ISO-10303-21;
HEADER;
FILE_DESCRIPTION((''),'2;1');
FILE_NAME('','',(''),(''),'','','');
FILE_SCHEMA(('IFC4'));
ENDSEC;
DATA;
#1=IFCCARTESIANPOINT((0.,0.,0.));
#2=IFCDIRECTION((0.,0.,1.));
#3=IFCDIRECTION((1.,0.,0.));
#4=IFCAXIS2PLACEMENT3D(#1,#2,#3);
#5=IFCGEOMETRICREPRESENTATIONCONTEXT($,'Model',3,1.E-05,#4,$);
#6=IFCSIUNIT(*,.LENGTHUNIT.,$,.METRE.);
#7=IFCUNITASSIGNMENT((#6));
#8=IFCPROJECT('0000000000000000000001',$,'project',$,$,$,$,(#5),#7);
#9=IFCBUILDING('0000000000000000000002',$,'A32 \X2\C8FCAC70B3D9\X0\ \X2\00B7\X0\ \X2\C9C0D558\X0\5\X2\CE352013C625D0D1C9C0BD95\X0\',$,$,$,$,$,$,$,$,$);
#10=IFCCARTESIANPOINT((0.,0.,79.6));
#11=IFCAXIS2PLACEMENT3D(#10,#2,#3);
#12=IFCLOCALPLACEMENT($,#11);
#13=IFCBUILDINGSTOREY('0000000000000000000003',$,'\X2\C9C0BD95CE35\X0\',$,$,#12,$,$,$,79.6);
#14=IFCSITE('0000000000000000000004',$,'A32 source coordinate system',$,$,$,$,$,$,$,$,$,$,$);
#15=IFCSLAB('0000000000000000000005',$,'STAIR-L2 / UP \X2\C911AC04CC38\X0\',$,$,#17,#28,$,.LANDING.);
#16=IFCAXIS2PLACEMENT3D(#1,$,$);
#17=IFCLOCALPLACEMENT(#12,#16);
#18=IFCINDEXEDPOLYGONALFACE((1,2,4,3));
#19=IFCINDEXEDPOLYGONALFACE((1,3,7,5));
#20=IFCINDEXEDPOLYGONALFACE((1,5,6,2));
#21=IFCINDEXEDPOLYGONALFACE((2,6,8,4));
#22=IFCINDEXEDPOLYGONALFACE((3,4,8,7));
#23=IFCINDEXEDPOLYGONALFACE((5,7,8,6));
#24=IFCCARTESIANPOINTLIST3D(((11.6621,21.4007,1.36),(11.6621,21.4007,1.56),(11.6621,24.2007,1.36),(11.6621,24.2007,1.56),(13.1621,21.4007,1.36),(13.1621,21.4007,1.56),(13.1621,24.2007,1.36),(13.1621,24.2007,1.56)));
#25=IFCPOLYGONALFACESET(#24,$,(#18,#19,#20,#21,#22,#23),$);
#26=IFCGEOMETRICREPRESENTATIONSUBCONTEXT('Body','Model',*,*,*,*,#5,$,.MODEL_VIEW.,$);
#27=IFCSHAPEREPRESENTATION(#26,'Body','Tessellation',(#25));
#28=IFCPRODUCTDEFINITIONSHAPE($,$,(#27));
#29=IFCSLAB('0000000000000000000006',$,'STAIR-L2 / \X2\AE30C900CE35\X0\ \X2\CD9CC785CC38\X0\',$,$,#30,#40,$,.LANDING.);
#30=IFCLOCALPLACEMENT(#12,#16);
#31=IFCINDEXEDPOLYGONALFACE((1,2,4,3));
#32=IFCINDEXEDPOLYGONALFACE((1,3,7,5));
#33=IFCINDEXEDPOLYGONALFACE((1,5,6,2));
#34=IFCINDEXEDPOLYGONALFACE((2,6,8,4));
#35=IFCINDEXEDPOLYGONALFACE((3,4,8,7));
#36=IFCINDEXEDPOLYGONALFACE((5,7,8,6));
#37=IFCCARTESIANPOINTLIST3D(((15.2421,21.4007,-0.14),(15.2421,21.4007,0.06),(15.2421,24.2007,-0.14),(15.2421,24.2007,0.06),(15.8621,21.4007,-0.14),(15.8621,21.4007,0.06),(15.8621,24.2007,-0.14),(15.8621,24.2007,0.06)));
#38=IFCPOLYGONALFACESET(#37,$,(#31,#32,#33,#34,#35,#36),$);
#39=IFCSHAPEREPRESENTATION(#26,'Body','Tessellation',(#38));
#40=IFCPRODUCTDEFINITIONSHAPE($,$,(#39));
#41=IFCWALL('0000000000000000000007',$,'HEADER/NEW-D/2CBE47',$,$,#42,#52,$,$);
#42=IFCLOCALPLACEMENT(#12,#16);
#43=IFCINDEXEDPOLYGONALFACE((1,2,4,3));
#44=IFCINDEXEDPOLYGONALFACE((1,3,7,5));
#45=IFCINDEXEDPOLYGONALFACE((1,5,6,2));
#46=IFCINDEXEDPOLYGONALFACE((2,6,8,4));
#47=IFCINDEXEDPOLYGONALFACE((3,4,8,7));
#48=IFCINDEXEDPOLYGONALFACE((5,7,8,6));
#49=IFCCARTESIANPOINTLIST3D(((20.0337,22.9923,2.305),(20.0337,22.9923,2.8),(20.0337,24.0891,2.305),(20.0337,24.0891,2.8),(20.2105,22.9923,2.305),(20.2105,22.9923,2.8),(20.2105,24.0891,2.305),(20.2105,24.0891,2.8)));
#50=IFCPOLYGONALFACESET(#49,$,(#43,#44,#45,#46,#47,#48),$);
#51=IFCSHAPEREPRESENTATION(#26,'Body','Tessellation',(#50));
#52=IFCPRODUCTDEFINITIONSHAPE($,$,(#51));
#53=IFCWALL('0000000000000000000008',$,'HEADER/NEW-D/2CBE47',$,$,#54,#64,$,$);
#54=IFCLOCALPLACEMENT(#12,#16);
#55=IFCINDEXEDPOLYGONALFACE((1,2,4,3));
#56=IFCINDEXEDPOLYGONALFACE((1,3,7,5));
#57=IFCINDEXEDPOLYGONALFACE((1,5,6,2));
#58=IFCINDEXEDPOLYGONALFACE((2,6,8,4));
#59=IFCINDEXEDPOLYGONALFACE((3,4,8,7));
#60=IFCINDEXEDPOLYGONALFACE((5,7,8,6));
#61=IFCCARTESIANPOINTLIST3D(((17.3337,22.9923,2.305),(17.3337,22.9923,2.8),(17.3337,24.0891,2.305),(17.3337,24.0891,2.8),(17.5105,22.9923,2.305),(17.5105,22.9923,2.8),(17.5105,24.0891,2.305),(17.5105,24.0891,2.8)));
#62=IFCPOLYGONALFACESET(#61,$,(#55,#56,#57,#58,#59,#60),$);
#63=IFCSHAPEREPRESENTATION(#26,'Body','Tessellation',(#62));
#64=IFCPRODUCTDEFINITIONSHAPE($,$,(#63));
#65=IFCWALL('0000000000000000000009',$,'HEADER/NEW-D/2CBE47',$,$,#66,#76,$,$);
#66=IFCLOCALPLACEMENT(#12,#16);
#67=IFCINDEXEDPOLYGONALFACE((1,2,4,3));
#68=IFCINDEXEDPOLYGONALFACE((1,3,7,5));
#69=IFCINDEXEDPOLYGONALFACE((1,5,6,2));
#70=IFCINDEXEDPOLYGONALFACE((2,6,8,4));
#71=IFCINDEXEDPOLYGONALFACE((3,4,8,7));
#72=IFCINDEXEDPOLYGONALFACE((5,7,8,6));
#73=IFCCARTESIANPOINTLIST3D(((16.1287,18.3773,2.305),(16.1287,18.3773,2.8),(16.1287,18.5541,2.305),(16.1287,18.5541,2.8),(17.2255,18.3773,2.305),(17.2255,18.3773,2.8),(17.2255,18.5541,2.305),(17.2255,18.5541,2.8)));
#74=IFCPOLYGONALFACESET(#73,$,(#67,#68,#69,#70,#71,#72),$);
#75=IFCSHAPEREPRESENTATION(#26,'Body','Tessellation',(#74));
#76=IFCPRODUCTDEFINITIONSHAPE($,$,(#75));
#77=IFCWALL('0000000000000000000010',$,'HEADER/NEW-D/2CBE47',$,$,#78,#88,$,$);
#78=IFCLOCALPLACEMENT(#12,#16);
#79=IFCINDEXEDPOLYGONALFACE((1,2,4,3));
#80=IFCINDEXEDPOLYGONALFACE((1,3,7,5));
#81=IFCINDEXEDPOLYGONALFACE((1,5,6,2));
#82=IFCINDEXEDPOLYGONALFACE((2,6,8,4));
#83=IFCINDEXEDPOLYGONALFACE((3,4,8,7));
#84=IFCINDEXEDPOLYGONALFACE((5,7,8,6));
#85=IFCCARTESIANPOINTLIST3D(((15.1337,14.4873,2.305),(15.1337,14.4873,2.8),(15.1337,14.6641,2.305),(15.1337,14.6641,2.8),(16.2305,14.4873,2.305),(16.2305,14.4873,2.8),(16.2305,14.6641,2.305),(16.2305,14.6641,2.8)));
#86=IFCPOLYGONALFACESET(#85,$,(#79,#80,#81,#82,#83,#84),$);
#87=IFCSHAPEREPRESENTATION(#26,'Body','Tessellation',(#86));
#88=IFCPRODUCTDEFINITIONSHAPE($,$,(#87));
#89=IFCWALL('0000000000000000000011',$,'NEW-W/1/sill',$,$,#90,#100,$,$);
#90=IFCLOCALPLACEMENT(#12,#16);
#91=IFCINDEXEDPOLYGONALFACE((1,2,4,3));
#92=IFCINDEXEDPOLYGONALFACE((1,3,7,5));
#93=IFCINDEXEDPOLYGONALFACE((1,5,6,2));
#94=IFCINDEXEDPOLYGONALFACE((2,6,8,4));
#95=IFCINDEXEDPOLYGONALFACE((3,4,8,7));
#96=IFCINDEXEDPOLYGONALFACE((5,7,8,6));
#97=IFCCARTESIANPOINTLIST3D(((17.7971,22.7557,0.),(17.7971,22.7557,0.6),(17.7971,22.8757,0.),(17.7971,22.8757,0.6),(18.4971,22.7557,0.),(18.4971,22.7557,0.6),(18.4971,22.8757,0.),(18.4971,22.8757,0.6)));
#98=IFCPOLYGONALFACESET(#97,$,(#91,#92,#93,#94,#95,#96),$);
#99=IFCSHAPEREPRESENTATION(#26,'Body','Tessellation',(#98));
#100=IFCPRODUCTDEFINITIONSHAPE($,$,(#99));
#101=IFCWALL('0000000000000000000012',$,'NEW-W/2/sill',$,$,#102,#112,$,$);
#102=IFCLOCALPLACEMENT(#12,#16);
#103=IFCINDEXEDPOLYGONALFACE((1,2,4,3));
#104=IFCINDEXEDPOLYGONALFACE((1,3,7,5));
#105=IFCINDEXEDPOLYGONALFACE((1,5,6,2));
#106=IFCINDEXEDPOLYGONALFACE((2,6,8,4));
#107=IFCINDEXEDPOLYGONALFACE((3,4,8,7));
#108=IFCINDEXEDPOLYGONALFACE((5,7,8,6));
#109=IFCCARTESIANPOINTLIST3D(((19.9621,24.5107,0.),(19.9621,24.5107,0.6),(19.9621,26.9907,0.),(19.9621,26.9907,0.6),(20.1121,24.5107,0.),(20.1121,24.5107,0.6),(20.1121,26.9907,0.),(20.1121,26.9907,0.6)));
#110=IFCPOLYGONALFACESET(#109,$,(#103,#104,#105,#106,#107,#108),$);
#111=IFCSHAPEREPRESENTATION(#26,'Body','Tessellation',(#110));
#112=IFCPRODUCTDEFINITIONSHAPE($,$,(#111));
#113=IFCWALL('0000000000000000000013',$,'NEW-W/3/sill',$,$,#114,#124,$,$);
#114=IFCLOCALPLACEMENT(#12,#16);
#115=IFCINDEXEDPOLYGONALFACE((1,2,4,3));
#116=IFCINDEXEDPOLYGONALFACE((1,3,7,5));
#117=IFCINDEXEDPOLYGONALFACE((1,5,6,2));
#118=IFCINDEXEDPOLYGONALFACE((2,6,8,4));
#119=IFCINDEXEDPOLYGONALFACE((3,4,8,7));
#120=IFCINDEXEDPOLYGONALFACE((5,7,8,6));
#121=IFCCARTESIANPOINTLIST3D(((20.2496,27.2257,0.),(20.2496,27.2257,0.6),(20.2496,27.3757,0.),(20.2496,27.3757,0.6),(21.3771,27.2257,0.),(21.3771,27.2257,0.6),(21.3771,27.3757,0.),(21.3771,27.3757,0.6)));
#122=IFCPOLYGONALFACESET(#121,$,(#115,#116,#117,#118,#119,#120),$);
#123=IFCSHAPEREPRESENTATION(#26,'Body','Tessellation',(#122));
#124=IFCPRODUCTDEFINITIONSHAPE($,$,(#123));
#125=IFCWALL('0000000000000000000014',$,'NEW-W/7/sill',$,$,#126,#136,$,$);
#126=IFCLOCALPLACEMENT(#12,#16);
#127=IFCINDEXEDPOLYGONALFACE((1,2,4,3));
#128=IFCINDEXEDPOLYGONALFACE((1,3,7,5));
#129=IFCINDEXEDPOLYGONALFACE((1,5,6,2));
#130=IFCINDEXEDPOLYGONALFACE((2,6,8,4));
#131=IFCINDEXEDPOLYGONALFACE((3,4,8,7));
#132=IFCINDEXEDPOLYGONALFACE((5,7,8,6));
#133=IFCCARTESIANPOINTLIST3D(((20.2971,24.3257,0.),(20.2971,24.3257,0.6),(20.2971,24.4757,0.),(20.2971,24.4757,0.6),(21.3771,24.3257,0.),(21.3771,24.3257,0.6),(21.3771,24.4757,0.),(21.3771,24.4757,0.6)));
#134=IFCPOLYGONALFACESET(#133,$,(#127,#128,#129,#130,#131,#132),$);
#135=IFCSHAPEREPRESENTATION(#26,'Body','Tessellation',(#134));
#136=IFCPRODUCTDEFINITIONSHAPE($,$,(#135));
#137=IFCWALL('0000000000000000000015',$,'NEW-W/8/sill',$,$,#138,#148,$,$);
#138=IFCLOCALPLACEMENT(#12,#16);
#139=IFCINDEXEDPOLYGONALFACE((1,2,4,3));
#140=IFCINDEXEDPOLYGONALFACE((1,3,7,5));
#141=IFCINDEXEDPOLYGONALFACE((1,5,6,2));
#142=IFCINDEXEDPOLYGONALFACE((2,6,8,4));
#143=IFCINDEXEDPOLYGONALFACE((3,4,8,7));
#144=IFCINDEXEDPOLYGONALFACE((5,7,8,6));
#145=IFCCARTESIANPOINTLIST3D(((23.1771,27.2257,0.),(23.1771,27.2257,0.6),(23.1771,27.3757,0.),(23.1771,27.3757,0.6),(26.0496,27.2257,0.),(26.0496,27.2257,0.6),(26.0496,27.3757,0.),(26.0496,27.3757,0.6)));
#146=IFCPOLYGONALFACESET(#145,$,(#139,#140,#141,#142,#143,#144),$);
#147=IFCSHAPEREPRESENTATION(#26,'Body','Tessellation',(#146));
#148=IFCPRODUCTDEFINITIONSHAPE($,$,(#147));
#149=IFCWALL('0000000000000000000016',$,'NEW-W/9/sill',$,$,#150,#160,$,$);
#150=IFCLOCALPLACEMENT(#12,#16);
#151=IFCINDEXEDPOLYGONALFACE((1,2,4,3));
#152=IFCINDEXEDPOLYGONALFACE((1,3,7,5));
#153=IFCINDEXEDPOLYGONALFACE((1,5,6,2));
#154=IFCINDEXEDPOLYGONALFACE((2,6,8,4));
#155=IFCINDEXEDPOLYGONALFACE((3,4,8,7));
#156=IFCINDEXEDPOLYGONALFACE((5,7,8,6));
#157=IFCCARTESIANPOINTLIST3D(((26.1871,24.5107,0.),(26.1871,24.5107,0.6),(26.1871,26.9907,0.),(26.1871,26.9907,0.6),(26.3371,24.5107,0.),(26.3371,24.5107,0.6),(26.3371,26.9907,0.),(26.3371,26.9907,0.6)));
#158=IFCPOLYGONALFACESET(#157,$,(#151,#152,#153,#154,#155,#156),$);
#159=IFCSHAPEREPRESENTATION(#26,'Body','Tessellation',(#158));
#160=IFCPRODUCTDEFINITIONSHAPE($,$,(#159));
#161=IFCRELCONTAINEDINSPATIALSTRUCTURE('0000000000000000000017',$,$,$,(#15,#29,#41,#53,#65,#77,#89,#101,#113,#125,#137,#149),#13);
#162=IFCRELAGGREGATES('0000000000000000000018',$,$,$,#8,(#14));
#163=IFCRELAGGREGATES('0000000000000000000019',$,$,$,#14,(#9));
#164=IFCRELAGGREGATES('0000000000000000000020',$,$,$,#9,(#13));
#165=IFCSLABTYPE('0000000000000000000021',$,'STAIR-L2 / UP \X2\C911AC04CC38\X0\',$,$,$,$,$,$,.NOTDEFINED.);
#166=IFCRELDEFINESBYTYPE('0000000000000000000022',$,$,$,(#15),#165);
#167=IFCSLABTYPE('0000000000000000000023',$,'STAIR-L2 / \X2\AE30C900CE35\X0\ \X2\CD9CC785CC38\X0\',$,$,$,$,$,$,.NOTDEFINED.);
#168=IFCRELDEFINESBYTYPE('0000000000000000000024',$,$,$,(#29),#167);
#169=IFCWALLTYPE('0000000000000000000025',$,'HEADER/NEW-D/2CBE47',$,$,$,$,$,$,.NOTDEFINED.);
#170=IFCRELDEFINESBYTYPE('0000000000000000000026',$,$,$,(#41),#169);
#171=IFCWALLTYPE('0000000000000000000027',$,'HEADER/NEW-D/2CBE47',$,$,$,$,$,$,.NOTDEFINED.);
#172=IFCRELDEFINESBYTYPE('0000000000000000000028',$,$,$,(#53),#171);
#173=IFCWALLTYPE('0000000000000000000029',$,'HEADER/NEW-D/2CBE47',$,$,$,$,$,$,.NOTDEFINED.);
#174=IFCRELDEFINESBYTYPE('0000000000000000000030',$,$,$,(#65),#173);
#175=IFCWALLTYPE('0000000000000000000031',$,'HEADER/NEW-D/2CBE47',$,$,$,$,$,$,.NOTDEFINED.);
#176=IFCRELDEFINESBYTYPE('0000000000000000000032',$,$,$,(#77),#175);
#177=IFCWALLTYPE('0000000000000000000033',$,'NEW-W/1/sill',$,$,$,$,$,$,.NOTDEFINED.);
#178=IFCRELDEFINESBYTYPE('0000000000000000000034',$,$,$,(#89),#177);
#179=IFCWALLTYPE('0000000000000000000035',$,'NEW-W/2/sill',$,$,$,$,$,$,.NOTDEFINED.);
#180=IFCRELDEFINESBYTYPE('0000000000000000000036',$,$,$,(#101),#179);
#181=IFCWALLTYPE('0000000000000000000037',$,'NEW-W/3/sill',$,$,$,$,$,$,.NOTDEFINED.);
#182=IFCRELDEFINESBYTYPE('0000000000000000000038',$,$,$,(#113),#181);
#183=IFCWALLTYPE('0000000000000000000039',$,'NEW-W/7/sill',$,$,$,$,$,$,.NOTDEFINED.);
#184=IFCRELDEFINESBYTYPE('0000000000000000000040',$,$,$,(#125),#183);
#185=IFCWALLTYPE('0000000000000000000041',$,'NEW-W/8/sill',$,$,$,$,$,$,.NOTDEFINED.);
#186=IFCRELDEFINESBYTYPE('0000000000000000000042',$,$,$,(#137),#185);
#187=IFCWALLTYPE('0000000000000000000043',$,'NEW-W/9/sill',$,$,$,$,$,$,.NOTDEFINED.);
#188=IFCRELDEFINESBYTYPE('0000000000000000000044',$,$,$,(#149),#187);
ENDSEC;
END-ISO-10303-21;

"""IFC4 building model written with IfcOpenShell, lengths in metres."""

from ifc_helpers import new_model, si_unit, frame, origin, origin_with_axes, place, context, subcontext, project, spatial, polyline, outline, extrude, source, transform, mapped, type_object, type_shapes, element, save


model = new_model("IFC4")

# Units and contexts
model_context = context("Model", 3, precision=1e-05, world=origin_with_axes())
body_context = subcontext(model_context, "Body", "Model", "MODEL_VIEW")
ifc_project = project(units=[si_unit("LENGTHUNIT", "METRE")], contexts=[model_context])

# Site, building, storey
site = spatial("IfcSite", under=ifc_project, Name="A32 source coordinate system")
building = spatial("IfcBuilding", under=site, Name="A32 주거동 · 지하5층–옥탑지붕")
storey_placement = place(None, frame((0.0, 0.0, 79.6), z_axis=(0.0, 0.0, 1.0), x_axis=(1.0, 0.0, 0.0)))
storey = spatial("IfcBuildingStorey", under=building, at=storey_placement, Name="지붕층", Elevation=79.6)

# Slabs
slab_type_1 = type_object("IfcSlabType", Name="STAIR-L2 / UP 중간참", PredefinedType="NOTDEFINED")
shared_shape_1 = source(origin(), body_context, "Body", "SweptSolid", [
    extrude(outline(polyline([(11.6621, 21.4007), (11.6621, 24.2007), (13.1621, 24.2007), (13.1621, 21.4007), (11.6621, 21.4007)])), frame((0.0, 0.0, 1.36)), (0.0, 0.0, 1.0), 0.2),
])
type_shapes(slab_type_1, [shared_shape_1])
slab_1_placement = place(storey_placement, origin_with_axes())
element("IfcSlab", 1, at=slab_1_placement, inside=storey, type_object=slab_type_1, Name="STAIR-L2 / UP 중간참", PredefinedType="LANDING", context=body_context, shape_type="MappedRepresentation", body=[
    mapped(shared_shape_1, transform((0.0, 0.0, 0.0), scale=1.0)),
])
slab_type_2 = type_object("IfcSlabType", Name="STAIR-L2 / 기준층 출입참", PredefinedType="NOTDEFINED")
shared_shape_2 = source(origin(), body_context, "Body", "SweptSolid", [
    extrude(outline(polyline([(15.2421, 21.4007), (15.2421, 24.2007), (15.8621, 24.2007), (15.8621, 21.4007), (15.2421, 21.4007)])), frame((0.0, 0.0, -0.14)), (0.0, 0.0, 1.0), 0.2),
])
type_shapes(slab_type_2, [shared_shape_2])
slab_2_placement = place(storey_placement, origin_with_axes())
element("IfcSlab", 2, at=slab_2_placement, inside=storey, type_object=slab_type_2, Name="STAIR-L2 / 기준층 출입참", PredefinedType="LANDING", context=body_context, shape_type="MappedRepresentation", body=[
    mapped(shared_shape_2, transform((0.0, 0.0, 0.0), scale=1.0)),
])

# Walls
wall_type_1 = type_object("IfcWallType", Name="HEADER/NEW-D/2CBE47", PredefinedType="NOTDEFINED")
shared_shape_3 = source(origin(), body_context, "Body", "SweptSolid", [
    extrude(outline(polyline([(20.0337, 22.9923), (20.0337, 24.0891), (20.2105, 24.0891), (20.2105, 22.9923), (20.0337, 22.9923)])), frame((0.0, 0.0, 2.305)), (0.0, 0.0, 1.0), 0.495),
])
type_shapes(wall_type_1, [shared_shape_3])
wall_1_placement = place(storey_placement, origin_with_axes())
element("IfcWall", 3, at=wall_1_placement, inside=storey, type_object=wall_type_1, Name="HEADER/NEW-D/2CBE47", context=body_context, shape_type="MappedRepresentation", body=[
    mapped(shared_shape_3, transform((0.0, 0.0, 0.0), scale=1.0)),
])
wall_type_2 = type_object("IfcWallType", Name="HEADER/NEW-D/2CBE47", PredefinedType="NOTDEFINED")
shared_shape_4 = source(origin(), body_context, "Body", "SweptSolid", [
    extrude(outline(polyline([(17.3337, 22.9923), (17.3337, 24.0891), (17.5105, 24.0891), (17.5105, 22.9923), (17.3337, 22.9923)])), frame((0.0, 0.0, 2.305)), (0.0, 0.0, 1.0), 0.495),
])
type_shapes(wall_type_2, [shared_shape_4])
wall_2_placement = place(storey_placement, origin_with_axes())
element("IfcWall", 4, at=wall_2_placement, inside=storey, type_object=wall_type_2, Name="HEADER/NEW-D/2CBE47", context=body_context, shape_type="MappedRepresentation", body=[
    mapped(shared_shape_4, transform((0.0, 0.0, 0.0), scale=1.0)),
])
wall_type_3 = type_object("IfcWallType", Name="HEADER/NEW-D/2CBE47", PredefinedType="NOTDEFINED")
shared_shape_5 = source(origin(), body_context, "Body", "SweptSolid", [
    extrude(outline(polyline([(16.1287, 18.3773), (16.1287, 18.5541), (17.2255, 18.5541), (17.2255, 18.3773), (16.1287, 18.3773)])), frame((0.0, 0.0, 2.305)), (0.0, 0.0, 1.0), 0.495),
])
type_shapes(wall_type_3, [shared_shape_5])
wall_3_placement = place(storey_placement, origin_with_axes())
element("IfcWall", 5, at=wall_3_placement, inside=storey, type_object=wall_type_3, Name="HEADER/NEW-D/2CBE47", context=body_context, shape_type="MappedRepresentation", body=[
    mapped(shared_shape_5, transform((0.0, 0.0, 0.0), scale=1.0)),
])
wall_type_4 = type_object("IfcWallType", Name="HEADER/NEW-D/2CBE47", PredefinedType="NOTDEFINED")
shared_shape_6 = source(origin(), body_context, "Body", "SweptSolid", [
    extrude(outline(polyline([(15.1337, 14.4873), (15.1337, 14.6641), (16.2305, 14.6641), (16.2305, 14.4873), (15.1337, 14.4873)])), frame((0.0, 0.0, 2.305)), (0.0, 0.0, 1.0), 0.495),
])
type_shapes(wall_type_4, [shared_shape_6])
wall_4_placement = place(storey_placement, origin_with_axes())
element("IfcWall", 6, at=wall_4_placement, inside=storey, type_object=wall_type_4, Name="HEADER/NEW-D/2CBE47", context=body_context, shape_type="MappedRepresentation", body=[
    mapped(shared_shape_6, transform((0.0, 0.0, 0.0), scale=1.0)),
])
wall_type_5 = type_object("IfcWallType", Name="NEW-W/1/sill", PredefinedType="NOTDEFINED")
shared_shape_7 = source(origin(), body_context, "Body", "SweptSolid", [
    extrude(outline(polyline([(17.7971, 22.7557), (17.7971, 22.8757), (18.4971, 22.8757), (18.4971, 22.7557), (17.7971, 22.7557)])), origin(), (0.0, 0.0, 1.0), 0.6),
])
type_shapes(wall_type_5, [shared_shape_7])
wall_5_placement = place(storey_placement, origin_with_axes())
element("IfcWall", 7, at=wall_5_placement, inside=storey, type_object=wall_type_5, Name="NEW-W/1/sill", context=body_context, shape_type="MappedRepresentation", body=[
    mapped(shared_shape_7, transform((0.0, 0.0, 0.0), scale=1.0)),
])
wall_type_6 = type_object("IfcWallType", Name="NEW-W/2/sill", PredefinedType="NOTDEFINED")
shared_shape_8 = source(origin(), body_context, "Body", "SweptSolid", [
    extrude(outline(polyline([(19.9621, 24.5107), (19.9621, 26.9907), (20.1121, 26.9907), (20.1121, 24.5107), (19.9621, 24.5107)])), origin(), (0.0, 0.0, 1.0), 0.6),
])
type_shapes(wall_type_6, [shared_shape_8])
wall_6_placement = place(storey_placement, origin_with_axes())
element("IfcWall", 8, at=wall_6_placement, inside=storey, type_object=wall_type_6, Name="NEW-W/2/sill", context=body_context, shape_type="MappedRepresentation", body=[
    mapped(shared_shape_8, transform((0.0, 0.0, 0.0), scale=1.0)),
])
wall_type_7 = type_object("IfcWallType", Name="NEW-W/3/sill", PredefinedType="NOTDEFINED")
shared_shape_9 = source(origin(), body_context, "Body", "SweptSolid", [
    extrude(outline(polyline([(20.2496, 27.2257), (20.2496, 27.3757), (21.3771, 27.3757), (21.3771, 27.2257), (20.2496, 27.2257)])), origin(), (0.0, 0.0, 1.0), 0.6),
])
type_shapes(wall_type_7, [shared_shape_9])
wall_7_placement = place(storey_placement, origin_with_axes())
element("IfcWall", 9, at=wall_7_placement, inside=storey, type_object=wall_type_7, Name="NEW-W/3/sill", context=body_context, shape_type="MappedRepresentation", body=[
    mapped(shared_shape_9, transform((0.0, 0.0, 0.0), scale=1.0)),
])
wall_type_8 = type_object("IfcWallType", Name="NEW-W/7/sill", PredefinedType="NOTDEFINED")
shared_shape_10 = source(origin(), body_context, "Body", "SweptSolid", [
    extrude(outline(polyline([(20.2971, 24.3257), (20.2971, 24.4757), (21.3771, 24.4757), (21.3771, 24.3257), (20.2971, 24.3257)])), origin(), (0.0, 0.0, 1.0), 0.6),
])
type_shapes(wall_type_8, [shared_shape_10])
wall_8_placement = place(storey_placement, origin_with_axes())
element("IfcWall", 10, at=wall_8_placement, inside=storey, type_object=wall_type_8, Name="NEW-W/7/sill", context=body_context, shape_type="MappedRepresentation", body=[
    mapped(shared_shape_10, transform((0.0, 0.0, 0.0), scale=1.0)),
])
wall_type_9 = type_object("IfcWallType", Name="NEW-W/8/sill", PredefinedType="NOTDEFINED")
shared_shape_11 = source(origin(), body_context, "Body", "SweptSolid", [
    extrude(outline(polyline([(23.1771, 27.2257), (23.1771, 27.3757), (26.0496, 27.3757), (26.0496, 27.2257), (23.1771, 27.2257)])), origin(), (0.0, 0.0, 1.0), 0.6),
])
type_shapes(wall_type_9, [shared_shape_11])
wall_9_placement = place(storey_placement, origin_with_axes())
element("IfcWall", 11, at=wall_9_placement, inside=storey, type_object=wall_type_9, Name="NEW-W/8/sill", context=body_context, shape_type="MappedRepresentation", body=[
    mapped(shared_shape_11, transform((0.0, 0.0, 0.0), scale=1.0)),
])
wall_type_10 = type_object("IfcWallType", Name="NEW-W/9/sill", PredefinedType="NOTDEFINED")
shared_shape_12 = source(origin(), body_context, "Body", "SweptSolid", [
    extrude(outline(polyline([(26.1871, 24.5107), (26.1871, 26.9907), (26.3371, 26.9907), (26.3371, 24.5107), (26.1871, 24.5107)])), origin(), (0.0, 0.0, 1.0), 0.6),
])
type_shapes(wall_type_10, [shared_shape_12])
wall_10_placement = place(storey_placement, origin_with_axes())
element("IfcWall", 12, at=wall_10_placement, inside=storey, type_object=wall_type_10, Name="NEW-W/9/sill", context=body_context, shape_type="MappedRepresentation", body=[
    mapped(shared_shape_12, transform((0.0, 0.0, 0.0), scale=1.0)),
])

save(model, "model.ifc")
